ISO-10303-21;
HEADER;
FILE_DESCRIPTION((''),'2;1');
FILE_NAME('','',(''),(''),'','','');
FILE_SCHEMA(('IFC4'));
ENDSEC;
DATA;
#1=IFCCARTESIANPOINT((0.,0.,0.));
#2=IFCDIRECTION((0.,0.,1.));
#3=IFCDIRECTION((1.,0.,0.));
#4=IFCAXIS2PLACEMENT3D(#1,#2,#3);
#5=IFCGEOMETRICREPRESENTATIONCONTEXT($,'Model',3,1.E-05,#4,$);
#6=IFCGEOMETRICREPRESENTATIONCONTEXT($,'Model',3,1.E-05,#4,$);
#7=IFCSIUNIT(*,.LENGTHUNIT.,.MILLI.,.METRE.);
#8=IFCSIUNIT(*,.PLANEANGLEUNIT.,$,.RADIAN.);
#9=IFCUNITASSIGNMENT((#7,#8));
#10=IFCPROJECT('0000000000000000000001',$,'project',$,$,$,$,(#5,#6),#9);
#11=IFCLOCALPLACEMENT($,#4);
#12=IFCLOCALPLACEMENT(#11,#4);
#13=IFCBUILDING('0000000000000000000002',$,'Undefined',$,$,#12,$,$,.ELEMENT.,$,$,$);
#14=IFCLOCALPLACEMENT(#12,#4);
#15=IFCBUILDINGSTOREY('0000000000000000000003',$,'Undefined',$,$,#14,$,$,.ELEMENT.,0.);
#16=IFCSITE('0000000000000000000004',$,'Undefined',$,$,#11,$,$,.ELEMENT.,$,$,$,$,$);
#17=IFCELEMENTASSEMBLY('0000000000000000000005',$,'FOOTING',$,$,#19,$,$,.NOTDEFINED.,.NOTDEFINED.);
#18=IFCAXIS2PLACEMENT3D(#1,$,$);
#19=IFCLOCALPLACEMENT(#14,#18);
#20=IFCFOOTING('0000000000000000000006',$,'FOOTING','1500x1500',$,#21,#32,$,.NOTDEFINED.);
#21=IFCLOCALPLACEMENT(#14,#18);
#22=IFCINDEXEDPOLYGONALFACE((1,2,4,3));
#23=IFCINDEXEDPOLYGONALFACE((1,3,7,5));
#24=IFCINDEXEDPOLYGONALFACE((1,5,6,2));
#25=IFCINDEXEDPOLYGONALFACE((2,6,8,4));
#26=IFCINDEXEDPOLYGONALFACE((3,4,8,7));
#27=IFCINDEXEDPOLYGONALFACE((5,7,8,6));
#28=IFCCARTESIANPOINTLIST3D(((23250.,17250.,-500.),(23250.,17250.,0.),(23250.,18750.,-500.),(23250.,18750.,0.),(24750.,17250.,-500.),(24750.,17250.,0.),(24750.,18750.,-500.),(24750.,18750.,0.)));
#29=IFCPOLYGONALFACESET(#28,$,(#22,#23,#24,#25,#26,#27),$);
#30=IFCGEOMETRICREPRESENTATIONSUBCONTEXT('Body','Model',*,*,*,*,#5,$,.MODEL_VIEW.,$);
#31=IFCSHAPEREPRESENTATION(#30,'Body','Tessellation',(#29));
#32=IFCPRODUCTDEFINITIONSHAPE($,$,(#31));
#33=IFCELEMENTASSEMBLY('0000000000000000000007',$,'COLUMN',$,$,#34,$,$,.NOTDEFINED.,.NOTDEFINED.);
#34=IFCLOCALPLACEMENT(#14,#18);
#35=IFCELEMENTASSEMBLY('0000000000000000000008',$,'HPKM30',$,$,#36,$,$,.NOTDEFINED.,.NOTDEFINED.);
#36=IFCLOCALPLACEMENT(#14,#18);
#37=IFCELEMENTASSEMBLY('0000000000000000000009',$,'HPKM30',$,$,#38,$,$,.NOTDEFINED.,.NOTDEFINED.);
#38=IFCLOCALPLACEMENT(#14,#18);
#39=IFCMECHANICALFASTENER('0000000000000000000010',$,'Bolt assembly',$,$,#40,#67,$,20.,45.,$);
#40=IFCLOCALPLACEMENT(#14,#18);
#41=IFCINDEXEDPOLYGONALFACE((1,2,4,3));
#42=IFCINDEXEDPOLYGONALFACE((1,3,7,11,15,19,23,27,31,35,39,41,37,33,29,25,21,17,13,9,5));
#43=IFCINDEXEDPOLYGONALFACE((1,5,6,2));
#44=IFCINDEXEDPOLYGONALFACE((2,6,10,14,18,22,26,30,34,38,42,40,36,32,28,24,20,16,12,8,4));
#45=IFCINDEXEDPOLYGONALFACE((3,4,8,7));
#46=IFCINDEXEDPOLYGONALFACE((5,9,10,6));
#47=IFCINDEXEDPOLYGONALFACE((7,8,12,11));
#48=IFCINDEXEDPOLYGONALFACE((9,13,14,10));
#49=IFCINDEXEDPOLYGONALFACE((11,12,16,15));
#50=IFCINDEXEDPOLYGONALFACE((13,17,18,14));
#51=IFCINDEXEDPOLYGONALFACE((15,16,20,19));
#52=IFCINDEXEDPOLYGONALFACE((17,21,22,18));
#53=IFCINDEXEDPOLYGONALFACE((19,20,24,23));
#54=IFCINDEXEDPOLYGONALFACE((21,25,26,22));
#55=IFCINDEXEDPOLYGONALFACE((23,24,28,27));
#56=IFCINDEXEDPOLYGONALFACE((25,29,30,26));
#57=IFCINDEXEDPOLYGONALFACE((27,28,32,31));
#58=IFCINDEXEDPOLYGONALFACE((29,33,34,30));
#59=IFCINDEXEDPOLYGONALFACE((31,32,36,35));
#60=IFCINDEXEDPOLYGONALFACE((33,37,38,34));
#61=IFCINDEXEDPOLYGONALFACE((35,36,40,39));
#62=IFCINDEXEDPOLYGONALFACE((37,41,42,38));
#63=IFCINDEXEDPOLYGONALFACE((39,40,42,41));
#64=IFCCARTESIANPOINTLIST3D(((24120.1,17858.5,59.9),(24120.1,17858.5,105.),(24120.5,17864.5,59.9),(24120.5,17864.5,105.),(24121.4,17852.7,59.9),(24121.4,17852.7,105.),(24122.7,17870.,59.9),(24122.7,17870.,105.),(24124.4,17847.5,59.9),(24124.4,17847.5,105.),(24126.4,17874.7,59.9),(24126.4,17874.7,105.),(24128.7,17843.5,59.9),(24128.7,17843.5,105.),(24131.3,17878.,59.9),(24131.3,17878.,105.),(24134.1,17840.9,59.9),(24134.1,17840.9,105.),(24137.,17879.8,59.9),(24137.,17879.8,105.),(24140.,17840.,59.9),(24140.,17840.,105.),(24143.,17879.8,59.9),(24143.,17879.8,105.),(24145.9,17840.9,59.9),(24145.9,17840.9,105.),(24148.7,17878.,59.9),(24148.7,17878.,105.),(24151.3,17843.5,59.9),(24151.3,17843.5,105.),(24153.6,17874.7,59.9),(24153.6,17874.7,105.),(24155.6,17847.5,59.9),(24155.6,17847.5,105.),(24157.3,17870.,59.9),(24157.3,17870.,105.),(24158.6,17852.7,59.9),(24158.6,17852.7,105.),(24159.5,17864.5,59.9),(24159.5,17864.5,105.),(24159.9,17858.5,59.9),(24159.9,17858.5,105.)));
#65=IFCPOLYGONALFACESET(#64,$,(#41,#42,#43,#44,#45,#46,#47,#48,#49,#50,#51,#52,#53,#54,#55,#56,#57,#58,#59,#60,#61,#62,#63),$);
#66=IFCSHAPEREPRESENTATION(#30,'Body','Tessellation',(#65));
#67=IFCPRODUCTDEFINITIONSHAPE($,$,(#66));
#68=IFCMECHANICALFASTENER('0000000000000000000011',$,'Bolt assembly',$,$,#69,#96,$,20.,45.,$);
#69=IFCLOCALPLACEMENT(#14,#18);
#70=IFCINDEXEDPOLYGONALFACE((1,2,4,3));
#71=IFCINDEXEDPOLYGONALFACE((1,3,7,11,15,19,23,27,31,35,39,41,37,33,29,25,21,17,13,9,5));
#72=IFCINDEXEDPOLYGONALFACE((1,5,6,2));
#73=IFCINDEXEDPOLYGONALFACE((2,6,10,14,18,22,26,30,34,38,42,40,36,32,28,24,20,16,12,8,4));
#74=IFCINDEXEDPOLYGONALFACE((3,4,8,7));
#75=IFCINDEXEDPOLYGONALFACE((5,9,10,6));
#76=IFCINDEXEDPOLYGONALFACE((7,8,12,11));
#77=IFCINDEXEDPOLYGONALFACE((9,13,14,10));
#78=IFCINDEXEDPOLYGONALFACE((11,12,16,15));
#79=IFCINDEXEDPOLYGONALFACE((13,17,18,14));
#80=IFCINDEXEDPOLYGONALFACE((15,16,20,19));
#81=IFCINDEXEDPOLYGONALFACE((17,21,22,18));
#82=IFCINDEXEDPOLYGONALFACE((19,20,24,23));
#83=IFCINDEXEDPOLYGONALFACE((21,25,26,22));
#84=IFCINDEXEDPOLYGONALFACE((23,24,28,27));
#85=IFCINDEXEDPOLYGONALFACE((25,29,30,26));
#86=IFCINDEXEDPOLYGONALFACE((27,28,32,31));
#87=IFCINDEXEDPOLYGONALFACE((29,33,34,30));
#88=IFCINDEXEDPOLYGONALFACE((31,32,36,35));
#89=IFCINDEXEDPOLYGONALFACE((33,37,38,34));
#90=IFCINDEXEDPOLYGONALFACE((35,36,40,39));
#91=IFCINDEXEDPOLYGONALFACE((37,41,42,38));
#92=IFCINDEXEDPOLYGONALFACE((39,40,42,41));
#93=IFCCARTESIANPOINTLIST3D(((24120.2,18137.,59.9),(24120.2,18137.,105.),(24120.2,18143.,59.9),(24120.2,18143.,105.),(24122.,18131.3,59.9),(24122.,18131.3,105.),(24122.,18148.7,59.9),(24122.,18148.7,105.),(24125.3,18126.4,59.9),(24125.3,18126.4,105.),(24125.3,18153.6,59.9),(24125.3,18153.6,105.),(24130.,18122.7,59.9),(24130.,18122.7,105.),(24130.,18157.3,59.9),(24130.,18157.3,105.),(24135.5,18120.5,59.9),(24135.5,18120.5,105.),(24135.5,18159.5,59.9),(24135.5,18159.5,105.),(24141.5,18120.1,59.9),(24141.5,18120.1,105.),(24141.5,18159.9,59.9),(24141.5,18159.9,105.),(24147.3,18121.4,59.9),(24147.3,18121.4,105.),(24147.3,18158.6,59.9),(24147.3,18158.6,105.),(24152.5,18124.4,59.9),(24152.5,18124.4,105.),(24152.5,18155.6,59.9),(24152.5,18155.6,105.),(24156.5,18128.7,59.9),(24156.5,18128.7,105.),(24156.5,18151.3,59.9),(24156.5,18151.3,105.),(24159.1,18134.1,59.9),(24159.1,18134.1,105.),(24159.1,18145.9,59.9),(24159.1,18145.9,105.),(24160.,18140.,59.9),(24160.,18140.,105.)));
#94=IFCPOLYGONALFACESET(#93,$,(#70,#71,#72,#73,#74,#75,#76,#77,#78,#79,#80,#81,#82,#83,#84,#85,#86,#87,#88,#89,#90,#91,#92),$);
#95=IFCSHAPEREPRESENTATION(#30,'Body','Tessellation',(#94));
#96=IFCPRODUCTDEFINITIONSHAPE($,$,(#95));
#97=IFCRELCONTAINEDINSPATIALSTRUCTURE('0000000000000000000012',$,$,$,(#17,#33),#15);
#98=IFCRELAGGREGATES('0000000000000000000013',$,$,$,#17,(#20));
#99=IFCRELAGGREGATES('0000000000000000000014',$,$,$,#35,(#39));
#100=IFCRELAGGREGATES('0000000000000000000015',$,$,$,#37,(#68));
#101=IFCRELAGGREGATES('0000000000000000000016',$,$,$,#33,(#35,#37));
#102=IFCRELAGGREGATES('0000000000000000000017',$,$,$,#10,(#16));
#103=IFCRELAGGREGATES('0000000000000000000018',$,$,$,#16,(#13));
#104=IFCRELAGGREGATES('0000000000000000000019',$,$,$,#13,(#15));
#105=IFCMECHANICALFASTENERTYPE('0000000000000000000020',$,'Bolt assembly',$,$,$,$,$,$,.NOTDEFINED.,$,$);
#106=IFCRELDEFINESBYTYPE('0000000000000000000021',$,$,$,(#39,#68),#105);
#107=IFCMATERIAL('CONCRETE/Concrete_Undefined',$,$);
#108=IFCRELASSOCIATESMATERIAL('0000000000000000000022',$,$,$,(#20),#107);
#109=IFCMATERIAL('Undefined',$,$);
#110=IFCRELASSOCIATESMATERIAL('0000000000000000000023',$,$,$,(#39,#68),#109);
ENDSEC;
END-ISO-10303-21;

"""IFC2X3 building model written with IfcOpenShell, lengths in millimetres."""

from ifc_helpers import new_model, si_unit, frame, origin_with_axes, origin_2d_with_axis, place, context, subcontext, project, spatial, rectangle, circle, extrude, source, transform, mapped, material, type_object, element, aggregate, save


model = new_model("IFC2X3")

# Units and contexts
model_context_1 = context("Model", 3, precision=1e-05, world=origin_with_axes())
model_context_2 = context("Model", 3, precision=1e-05, world=origin_with_axes())
body_context = subcontext(model_context_1, "Body", "Model", "MODEL_VIEW")
ifc_project = project(units=[si_unit("LENGTHUNIT", "METRE", prefix="MILLI"), si_unit("PLANEANGLEUNIT", "RADIAN")], contexts=[model_context_1, model_context_2])

# Site, building, storey
site_placement = place(None, origin_with_axes())
site = spatial("IfcSite", under=ifc_project, at=site_placement, Name="Undefined", CompositionType="ELEMENT")
building_placement = place(site_placement, origin_with_axes())
building = spatial("IfcBuilding", under=site, at=building_placement, Name="Undefined", CompositionType="ELEMENT")
storey_placement = place(building_placement, origin_with_axes())
storey = spatial("IfcBuildingStorey", under=building, at=storey_placement, Name="Undefined", CompositionType="ELEMENT", Elevation=0.0)

# Element assembly, footing
assembly_1_placement = place(storey_placement, origin_with_axes())
assembly_1 = element("IfcElementAssembly", 1, at=assembly_1_placement, inside=storey, Name="FOOTING", AssemblyPlace="NOTDEFINED", PredefinedType="NOTDEFINED")
ifc_material_1 = material(Name="CONCRETE/Concrete_Undefined")
footing_placement = place(assembly_1_placement, frame((24000.0, 18000.0, -500.0), z_axis=(0.0, 1.0, 0.0), x_axis=(0.0, 0.0, 1.0)))
footing = element("IfcFooting", 2, at=footing_placement, material=ifc_material_1, Name="FOOTING", Description="1500x1500", PredefinedType="NOTDEFINED", context=body_context, shape_type="SweptSolid", body=[
    extrude(rectangle(XDim=1500.0, YDim=1500.0, at=origin_2d_with_axis()), frame((500.0, 0.0, 0.0), z_axis=(-1.0, 0.0, 0.0), x_axis=(0.0, -1.0, 0.0)), (0.0, 0.0, 1.0), 500.0),
])

# Element assemblies, mechanical fasteners
assembly_2_placement = place(storey_placement, origin_with_axes())
assembly_2 = element("IfcElementAssembly", 3, at=assembly_2_placement, inside=storey, Name="COLUMN", AssemblyPlace="NOTDEFINED", PredefinedType="NOTDEFINED")
assembly_3_placement = place(assembly_2_placement, origin_with_axes())
assembly_3 = element("IfcElementAssembly", 4, at=assembly_3_placement, Name="HPKM30", AssemblyPlace="NOTDEFINED", PredefinedType="NOTDEFINED")
assembly_4_placement = place(assembly_2_placement, origin_with_axes())
assembly_4 = element("IfcElementAssembly", 5, at=assembly_4_placement, Name="HPKM30", AssemblyPlace="NOTDEFINED", PredefinedType="NOTDEFINED")
ifc_material_2 = material(Name="Undefined")
mechanical_fastener_type = type_object("IfcMechanicalFastenerType", Name="Bolt assembly")
shared_shape_1 = source(origin_with_axes(), body_context, "Body", "SweptSolid", [
    extrude(circle(Radius=20.0, at=origin_2d_with_axis()), frame((0.0, -45.0, 0.0), z_axis=(0.0, 1.0, 0.0), x_axis=(1.0, 0.0, 0.0)), (0.0, 0.0, 1.0), 45.1),
])
mechanical_fastener_1_placement = place(assembly_3_placement, frame((24140.0, 17860.0, 60.0), z_axis=(1.0, 0.0, 0.0), x_axis=(0.0, -1.0, 0.0)))
mechanical_fastener_1 = element("IfcMechanicalFastener", 6, at=mechanical_fastener_1_placement, type_object=mechanical_fastener_type, material=ifc_material_2, Name="Bolt assembly", NominalDiameter=20.0, NominalLength=45.0, context=body_context, shape_type="MappedRepresentation", body=[
    mapped(shared_shape_1, transform((0.0, 0.0, 0.0))),
])
mechanical_fastener_2_placement = place(assembly_4_placement, frame((24140.0, 18140.0, 60.0), z_axis=(0.0, 1.0, 0.0), x_axis=(1.0, 0.0, 0.0)))
mechanical_fastener_2 = element("IfcMechanicalFastener", 7, at=mechanical_fastener_2_placement, type_object=mechanical_fastener_type, material=ifc_material_2, Name="Bolt assembly", NominalDiameter=20.0, NominalLength=45.0, context=body_context, shape_type="MappedRepresentation", body=[
    mapped(shared_shape_1, transform((0.0, 0.0, 0.0))),
])

aggregate(assembly_1, [footing])

aggregate(assembly_3, [mechanical_fastener_1])
aggregate(assembly_4, [mechanical_fastener_2])
aggregate(assembly_2, [assembly_3, assembly_4])

save(model, "model.ifc")
